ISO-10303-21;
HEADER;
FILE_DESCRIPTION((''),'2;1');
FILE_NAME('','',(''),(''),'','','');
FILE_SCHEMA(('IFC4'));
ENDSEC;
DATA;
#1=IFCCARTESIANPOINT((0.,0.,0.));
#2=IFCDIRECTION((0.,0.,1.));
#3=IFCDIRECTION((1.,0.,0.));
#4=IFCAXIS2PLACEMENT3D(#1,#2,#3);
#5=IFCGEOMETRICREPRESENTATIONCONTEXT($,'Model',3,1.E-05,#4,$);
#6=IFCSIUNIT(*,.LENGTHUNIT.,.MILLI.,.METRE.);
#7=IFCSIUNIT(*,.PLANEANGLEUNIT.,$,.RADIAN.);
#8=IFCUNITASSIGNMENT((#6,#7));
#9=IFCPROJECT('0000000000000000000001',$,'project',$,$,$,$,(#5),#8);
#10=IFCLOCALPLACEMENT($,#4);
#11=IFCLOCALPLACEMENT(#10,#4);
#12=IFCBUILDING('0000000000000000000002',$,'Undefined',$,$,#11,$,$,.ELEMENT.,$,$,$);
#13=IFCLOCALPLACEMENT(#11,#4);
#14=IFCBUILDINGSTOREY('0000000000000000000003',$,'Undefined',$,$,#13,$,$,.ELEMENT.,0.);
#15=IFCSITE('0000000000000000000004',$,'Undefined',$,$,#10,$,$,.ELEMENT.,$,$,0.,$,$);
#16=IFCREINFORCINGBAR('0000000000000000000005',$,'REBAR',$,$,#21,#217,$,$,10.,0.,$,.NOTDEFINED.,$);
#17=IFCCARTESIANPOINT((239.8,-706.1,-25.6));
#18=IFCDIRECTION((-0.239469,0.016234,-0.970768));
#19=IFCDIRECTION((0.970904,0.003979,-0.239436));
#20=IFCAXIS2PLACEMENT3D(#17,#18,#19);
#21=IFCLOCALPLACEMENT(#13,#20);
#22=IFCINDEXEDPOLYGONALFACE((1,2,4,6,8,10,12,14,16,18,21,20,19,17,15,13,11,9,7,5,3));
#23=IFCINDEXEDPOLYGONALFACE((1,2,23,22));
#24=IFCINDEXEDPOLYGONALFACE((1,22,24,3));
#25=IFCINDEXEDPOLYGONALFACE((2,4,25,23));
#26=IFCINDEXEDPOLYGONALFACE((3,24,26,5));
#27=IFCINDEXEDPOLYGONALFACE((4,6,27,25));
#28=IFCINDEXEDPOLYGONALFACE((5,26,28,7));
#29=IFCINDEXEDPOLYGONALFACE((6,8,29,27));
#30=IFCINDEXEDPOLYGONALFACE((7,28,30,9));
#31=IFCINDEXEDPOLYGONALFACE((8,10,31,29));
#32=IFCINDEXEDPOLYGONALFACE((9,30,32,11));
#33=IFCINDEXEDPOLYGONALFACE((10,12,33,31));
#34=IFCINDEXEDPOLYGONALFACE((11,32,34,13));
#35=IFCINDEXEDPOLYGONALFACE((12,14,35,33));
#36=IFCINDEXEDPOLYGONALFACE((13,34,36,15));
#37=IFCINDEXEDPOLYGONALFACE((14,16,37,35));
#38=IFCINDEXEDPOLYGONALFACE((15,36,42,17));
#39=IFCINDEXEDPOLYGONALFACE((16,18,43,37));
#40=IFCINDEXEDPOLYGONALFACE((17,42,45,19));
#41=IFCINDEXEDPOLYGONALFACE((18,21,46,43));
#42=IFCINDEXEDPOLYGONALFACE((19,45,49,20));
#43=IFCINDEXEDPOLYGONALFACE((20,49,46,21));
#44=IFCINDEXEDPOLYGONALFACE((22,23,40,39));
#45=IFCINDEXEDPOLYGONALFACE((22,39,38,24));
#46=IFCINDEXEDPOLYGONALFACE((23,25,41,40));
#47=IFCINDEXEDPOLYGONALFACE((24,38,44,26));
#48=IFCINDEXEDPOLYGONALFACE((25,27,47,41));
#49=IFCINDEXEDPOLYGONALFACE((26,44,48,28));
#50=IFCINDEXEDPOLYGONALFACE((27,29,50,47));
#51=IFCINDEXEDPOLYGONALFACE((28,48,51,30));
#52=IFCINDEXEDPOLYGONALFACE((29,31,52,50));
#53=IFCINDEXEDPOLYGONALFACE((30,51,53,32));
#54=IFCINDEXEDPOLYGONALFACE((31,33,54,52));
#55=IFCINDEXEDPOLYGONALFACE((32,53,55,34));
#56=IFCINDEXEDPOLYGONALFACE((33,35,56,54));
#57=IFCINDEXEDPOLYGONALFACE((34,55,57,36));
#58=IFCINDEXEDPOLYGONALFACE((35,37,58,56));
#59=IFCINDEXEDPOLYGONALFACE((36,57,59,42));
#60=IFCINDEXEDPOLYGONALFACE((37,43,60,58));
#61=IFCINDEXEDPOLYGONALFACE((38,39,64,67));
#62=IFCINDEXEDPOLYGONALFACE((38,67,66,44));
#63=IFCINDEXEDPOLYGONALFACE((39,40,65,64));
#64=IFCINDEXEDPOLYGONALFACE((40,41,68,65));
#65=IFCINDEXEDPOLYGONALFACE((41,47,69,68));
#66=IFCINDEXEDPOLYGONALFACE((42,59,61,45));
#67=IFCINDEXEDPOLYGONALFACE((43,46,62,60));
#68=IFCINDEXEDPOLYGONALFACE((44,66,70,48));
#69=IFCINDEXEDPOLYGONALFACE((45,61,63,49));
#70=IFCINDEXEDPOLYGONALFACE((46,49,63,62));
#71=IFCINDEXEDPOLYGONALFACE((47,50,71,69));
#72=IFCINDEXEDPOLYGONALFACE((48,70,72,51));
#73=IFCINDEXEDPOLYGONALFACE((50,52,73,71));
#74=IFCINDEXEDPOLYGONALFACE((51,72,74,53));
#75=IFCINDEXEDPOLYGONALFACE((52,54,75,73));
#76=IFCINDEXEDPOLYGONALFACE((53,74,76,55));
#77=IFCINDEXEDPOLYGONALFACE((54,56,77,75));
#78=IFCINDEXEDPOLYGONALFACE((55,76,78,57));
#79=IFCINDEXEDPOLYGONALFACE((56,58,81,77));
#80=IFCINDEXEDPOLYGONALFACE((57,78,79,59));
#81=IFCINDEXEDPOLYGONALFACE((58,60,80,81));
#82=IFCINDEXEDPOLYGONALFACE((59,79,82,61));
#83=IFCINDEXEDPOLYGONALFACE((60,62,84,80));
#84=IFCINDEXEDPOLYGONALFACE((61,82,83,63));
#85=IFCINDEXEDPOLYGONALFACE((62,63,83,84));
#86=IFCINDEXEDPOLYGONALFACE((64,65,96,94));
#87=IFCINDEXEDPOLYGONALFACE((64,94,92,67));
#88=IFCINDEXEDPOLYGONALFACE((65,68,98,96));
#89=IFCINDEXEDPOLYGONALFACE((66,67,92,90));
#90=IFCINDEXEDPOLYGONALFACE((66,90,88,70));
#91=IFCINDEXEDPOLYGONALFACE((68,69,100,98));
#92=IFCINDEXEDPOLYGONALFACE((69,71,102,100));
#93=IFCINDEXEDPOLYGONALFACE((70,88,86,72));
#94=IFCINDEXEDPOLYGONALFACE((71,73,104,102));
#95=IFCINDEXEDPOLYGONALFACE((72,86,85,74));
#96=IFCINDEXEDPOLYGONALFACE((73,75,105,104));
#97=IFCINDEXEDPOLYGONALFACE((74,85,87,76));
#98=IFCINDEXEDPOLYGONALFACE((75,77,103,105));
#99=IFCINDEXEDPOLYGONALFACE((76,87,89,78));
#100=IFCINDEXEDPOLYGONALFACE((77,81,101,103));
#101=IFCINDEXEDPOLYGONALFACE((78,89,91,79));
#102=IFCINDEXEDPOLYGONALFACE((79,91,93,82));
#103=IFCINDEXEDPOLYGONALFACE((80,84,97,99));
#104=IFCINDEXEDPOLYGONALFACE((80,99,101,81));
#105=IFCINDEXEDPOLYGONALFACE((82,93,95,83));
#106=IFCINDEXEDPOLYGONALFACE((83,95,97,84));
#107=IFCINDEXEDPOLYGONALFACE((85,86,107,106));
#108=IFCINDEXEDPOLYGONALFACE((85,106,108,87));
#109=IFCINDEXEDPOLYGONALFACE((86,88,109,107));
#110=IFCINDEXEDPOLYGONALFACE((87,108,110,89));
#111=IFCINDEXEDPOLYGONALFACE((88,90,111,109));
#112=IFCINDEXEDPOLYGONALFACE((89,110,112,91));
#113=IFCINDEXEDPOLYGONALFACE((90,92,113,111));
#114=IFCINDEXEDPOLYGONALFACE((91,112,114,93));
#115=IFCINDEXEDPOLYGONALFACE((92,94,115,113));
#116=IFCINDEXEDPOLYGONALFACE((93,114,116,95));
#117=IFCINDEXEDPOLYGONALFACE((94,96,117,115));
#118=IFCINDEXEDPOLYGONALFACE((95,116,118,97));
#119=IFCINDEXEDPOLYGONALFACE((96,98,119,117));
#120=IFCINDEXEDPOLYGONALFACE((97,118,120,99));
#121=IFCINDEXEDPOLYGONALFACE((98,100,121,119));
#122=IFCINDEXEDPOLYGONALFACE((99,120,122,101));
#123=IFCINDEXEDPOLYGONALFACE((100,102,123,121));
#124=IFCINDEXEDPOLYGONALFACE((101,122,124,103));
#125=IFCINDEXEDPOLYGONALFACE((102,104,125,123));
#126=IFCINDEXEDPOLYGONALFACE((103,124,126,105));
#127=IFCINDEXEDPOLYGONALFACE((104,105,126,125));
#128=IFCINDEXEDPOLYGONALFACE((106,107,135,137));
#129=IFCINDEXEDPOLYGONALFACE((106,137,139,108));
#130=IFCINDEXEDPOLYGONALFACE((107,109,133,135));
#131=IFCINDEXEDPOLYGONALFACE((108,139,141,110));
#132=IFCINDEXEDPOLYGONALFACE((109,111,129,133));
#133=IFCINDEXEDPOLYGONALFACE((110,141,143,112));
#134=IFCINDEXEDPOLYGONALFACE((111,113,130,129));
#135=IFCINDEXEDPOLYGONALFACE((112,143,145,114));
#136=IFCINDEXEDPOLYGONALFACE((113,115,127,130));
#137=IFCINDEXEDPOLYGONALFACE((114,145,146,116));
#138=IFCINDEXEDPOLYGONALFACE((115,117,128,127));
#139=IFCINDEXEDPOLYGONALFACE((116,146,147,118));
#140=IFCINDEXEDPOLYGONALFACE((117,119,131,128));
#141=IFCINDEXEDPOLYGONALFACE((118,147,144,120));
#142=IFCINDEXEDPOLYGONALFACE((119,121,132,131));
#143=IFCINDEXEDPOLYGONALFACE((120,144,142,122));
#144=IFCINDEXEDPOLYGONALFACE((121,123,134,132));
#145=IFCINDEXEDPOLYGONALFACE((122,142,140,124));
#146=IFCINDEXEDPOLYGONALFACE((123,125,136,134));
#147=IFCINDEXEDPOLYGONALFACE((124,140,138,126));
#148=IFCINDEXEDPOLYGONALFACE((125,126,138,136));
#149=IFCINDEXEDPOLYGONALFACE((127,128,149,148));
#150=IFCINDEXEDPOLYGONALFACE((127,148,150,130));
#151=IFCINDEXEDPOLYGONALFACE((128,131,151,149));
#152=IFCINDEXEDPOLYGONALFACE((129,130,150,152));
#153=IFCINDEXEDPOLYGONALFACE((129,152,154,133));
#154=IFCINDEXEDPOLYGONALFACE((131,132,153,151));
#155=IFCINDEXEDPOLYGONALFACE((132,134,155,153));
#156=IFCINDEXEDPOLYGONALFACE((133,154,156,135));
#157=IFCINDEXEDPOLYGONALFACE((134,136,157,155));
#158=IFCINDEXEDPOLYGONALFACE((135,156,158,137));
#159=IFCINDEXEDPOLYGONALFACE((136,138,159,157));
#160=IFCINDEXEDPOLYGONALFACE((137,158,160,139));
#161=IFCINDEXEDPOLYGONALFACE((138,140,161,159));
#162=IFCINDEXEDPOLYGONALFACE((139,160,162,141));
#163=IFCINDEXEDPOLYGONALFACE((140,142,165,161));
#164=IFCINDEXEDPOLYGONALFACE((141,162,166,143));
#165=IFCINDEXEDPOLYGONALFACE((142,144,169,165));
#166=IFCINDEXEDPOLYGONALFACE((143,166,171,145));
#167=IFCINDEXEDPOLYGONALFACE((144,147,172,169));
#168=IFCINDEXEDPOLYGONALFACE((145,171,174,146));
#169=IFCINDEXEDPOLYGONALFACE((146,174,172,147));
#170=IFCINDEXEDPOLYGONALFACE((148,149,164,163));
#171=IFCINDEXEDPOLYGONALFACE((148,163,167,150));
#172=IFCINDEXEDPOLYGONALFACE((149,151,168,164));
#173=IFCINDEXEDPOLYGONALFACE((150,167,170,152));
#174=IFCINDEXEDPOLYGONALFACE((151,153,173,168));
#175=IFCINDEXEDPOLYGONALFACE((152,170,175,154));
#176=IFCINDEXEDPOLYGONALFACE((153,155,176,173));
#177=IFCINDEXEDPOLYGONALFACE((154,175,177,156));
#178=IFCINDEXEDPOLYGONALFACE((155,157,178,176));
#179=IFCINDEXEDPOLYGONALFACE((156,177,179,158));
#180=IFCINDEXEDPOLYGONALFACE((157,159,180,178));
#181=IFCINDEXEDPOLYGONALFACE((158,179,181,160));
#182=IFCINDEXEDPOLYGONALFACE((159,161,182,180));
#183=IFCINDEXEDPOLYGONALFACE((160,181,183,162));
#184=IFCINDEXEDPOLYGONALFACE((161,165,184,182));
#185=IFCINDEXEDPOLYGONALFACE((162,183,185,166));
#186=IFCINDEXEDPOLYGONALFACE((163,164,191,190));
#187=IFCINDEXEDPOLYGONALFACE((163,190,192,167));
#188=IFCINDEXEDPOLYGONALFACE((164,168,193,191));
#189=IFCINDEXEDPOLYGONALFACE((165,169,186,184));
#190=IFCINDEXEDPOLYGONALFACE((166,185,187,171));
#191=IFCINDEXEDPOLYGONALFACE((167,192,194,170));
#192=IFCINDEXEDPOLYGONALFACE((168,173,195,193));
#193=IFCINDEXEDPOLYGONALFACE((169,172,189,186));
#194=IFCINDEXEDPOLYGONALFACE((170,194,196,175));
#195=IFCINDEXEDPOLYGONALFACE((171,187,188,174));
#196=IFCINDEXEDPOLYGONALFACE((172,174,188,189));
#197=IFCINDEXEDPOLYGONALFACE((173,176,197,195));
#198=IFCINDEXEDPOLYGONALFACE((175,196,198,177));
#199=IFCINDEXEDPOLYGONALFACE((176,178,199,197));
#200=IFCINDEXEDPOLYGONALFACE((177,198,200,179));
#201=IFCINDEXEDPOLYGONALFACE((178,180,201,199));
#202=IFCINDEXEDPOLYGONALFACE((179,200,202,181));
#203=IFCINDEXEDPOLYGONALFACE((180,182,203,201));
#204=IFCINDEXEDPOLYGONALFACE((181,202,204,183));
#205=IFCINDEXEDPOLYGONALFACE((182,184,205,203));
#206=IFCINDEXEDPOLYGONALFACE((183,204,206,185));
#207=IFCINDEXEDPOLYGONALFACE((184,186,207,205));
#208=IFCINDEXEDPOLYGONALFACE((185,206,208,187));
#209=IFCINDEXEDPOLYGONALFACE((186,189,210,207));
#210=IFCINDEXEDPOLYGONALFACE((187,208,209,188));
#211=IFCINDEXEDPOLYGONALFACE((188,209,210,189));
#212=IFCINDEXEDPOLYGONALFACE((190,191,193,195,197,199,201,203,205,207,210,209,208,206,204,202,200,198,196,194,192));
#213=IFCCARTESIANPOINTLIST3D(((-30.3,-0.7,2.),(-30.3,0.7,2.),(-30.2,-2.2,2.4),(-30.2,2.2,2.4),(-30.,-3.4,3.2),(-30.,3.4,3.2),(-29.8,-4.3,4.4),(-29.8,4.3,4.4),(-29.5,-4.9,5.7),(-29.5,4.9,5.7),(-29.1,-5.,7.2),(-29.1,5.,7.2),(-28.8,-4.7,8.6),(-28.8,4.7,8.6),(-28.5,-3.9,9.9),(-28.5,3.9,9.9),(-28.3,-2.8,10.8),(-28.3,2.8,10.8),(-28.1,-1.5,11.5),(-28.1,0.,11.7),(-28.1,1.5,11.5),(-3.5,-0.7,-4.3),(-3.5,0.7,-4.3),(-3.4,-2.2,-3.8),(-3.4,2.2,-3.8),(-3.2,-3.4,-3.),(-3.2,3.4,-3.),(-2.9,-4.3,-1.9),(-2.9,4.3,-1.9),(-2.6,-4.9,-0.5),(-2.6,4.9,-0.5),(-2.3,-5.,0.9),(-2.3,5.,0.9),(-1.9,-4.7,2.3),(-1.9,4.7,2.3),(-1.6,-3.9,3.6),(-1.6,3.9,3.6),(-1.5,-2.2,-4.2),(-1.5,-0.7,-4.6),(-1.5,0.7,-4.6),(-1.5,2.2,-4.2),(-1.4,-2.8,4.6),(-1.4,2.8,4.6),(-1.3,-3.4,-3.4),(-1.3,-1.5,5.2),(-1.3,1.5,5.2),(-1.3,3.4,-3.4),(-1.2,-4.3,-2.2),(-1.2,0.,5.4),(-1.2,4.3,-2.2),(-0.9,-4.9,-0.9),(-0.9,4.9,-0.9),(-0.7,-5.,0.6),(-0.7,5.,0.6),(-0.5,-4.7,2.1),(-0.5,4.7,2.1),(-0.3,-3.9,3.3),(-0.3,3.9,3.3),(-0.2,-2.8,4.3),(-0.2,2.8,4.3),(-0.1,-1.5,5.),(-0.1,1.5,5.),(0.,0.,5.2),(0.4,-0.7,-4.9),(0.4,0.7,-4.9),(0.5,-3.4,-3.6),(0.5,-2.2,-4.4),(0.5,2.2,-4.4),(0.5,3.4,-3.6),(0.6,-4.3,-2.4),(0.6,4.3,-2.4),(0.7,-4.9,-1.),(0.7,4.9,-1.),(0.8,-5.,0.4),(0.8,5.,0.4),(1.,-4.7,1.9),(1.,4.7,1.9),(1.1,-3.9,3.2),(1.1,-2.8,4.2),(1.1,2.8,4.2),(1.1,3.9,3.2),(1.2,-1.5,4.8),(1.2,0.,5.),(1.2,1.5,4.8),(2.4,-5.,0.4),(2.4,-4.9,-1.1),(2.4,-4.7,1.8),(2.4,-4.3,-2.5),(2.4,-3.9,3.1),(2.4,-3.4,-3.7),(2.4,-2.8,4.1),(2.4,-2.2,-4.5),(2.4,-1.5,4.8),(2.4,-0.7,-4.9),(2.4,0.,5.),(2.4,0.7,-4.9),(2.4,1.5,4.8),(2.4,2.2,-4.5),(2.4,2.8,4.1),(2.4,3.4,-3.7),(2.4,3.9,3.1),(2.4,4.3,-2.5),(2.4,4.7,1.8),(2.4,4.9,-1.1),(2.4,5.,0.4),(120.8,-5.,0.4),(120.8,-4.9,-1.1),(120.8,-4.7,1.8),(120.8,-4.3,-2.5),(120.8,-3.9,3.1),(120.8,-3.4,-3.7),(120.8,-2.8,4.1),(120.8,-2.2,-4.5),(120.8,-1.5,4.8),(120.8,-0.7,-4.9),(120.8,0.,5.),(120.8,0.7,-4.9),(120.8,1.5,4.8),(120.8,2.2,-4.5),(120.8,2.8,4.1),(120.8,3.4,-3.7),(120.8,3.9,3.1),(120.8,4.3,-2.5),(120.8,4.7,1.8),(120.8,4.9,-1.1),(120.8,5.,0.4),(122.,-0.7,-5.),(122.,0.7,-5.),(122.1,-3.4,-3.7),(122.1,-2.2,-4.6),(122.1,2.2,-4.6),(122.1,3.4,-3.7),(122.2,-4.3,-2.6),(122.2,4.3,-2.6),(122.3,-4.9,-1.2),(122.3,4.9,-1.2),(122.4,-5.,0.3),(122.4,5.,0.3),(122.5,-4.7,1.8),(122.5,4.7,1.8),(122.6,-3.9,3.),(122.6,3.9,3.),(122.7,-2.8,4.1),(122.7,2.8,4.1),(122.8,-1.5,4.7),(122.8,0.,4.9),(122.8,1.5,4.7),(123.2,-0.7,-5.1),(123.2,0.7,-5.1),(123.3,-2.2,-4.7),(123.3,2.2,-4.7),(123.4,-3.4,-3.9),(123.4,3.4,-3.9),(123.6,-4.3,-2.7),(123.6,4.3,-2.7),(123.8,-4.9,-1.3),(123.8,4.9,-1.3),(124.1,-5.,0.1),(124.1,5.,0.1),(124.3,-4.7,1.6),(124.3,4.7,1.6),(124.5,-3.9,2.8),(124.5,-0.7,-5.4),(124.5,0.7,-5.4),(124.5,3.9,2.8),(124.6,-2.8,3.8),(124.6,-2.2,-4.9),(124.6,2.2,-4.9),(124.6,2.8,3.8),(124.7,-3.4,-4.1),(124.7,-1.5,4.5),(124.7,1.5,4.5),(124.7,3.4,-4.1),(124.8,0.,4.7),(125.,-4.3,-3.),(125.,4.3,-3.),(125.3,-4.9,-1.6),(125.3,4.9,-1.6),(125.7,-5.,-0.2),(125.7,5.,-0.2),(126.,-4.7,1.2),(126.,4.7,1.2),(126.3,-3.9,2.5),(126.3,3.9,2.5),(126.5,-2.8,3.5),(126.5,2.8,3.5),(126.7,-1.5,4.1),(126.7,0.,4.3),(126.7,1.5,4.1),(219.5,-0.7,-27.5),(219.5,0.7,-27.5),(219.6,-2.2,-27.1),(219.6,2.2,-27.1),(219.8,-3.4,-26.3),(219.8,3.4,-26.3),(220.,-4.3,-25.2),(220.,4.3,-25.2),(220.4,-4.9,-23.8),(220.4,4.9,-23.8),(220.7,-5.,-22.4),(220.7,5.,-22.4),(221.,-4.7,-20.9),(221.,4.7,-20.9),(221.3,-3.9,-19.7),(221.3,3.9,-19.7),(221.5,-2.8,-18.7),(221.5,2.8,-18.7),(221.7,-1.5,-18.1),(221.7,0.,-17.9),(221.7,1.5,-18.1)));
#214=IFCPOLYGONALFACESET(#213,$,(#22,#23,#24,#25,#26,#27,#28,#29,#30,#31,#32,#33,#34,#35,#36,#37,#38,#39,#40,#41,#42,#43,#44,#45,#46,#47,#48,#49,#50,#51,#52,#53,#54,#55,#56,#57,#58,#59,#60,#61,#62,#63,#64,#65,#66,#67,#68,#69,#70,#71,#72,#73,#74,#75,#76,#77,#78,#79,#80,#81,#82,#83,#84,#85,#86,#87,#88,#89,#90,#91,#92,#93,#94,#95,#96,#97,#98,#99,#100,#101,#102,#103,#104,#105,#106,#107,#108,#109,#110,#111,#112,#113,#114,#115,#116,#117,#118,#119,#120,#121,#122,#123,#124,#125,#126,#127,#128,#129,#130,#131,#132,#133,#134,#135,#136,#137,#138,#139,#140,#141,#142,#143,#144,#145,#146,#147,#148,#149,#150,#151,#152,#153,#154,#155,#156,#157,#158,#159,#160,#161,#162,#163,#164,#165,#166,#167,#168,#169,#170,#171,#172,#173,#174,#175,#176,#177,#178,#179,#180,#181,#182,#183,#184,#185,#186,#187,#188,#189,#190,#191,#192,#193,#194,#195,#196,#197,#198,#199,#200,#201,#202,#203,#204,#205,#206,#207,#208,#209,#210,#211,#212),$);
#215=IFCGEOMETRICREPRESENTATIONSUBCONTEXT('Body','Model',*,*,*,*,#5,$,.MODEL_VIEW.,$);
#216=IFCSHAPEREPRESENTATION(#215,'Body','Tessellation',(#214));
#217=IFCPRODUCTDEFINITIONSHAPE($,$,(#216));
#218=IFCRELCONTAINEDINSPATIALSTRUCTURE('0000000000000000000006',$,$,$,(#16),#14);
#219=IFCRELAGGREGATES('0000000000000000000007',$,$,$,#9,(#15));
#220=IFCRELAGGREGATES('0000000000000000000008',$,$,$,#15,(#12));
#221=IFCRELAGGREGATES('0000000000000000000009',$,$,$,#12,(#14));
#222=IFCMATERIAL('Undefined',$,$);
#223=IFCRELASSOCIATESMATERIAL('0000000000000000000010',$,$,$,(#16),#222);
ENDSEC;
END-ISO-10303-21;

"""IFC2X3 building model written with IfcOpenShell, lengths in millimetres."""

from ifc_helpers import new_model, entity, si_unit, frame, origin_with_axes, place, context, subcontext, project, spatial, source, transform, mapped, material, element, save


model = new_model("IFC2X3")

# Units and contexts
model_context = context("Model", 3, precision=1e-05, world=origin_with_axes())
body_context = subcontext(model_context, "Body", "Model", "MODEL_VIEW")
ifc_project = project(units=[si_unit("LENGTHUNIT", "METRE", prefix="MILLI"), si_unit("PLANEANGLEUNIT", "RADIAN")], contexts=[model_context])

# Site, building, storey
site_placement = place(None, origin_with_axes())
site = spatial("IfcSite", under=ifc_project, at=site_placement, Name="Undefined", CompositionType="ELEMENT", RefElevation=0.0)
building_placement = place(site_placement, origin_with_axes())
building = spatial("IfcBuilding", under=site, at=building_placement, Name="Undefined", CompositionType="ELEMENT")
storey_placement = place(building_placement, origin_with_axes())
storey = spatial("IfcBuildingStorey", under=building, at=storey_placement, Name="Undefined", CompositionType="ELEMENT", Elevation=0.0)

# Reinforcing bar
ifc_material_1 = material(Name="Undefined")
ifc_direction_1 = entity("IfcDirection", [0.973841, 0.0, -0.22723])
shared_shape_1 = source(origin_with_axes(), body_context, "Body", "AdvancedSweptSolid", [
    entity("IfcSweptDiskSolid", entity("IfcCompositeCurve", [entity("IfcCompositeCurveSegment", "CONTINUOUS", True, entity("IfcTrimmedCurve", entity("IfcLine", entity("IfcCartesianPoint", [0.0, 0.0, 0.0]), entity("IfcVector", ifc_direction_1, 1.0)), [entity("IfcParameterValue", 0.0)], [entity("IfcParameterValue", 27.582469)], True, "PARAMETER")), entity("IfcCompositeCurveSegment", "CONTINUOUS", True, entity("IfcTrimmedCurve", entity("IfcCircle", entity("IfcAxis2Placement3D", entity("IfcCartesianPoint", [31.6, 0.0, 14.2]), entity("IfcDirection", [0.0, -1.0, 0.0]), entity("IfcDirection", [-0.22723, 0.0, -0.973841])), 21.0), [entity("IfcParameterValue", 0.0)], [entity("IfcParameterValue", 0.229232)], True, "PARAMETER")), entity("IfcCompositeCurveSegment", "CONTINUOUS", True, entity("IfcTrimmedCurve", entity("IfcLine", entity("IfcCartesianPoint", [31.6, 0.0, -6.8]), entity("IfcVector", entity("IfcDirection", [1.0, 0.0, 0.0]), 1.0)), [entity("IfcParameterValue", 0.0)], [entity("IfcParameterValue", 118.388313)], True, "PARAMETER")), entity("IfcCompositeCurveSegment", "CONTINUOUS", True, entity("IfcTrimmedCurve", entity("IfcCircle", entity("IfcAxis2Placement3D", entity("IfcCartesianPoint", [150.0, 0.0, -27.8]), entity("IfcDirection", [0.0, 1.0, 0.0]), entity("IfcDirection", [0.0, 0.0, 1.0])), 21.0), [entity("IfcParameterValue", 0.0)], [entity("IfcParameterValue", 0.229232)], True, "PARAMETER")), entity("IfcCompositeCurveSegment", "DISCONTINUOUS", True, entity("IfcTrimmedCurve", entity("IfcLine", entity("IfcCartesianPoint", [154.8, 0.0, -7.4]), entity("IfcVector", ifc_direction_1, 1.0)), [entity("IfcParameterValue", 0.0)], [entity("IfcParameterValue", 97.582469)], True, "PARAMETER"))], False), 5.0, None, 0.0, 244.0),
])
reinforcing_bar_1_placement = place(storey_placement, frame((239.8, -706.1, -25.6), z_axis=(-0.239469, 0.016234, -0.970768), x_axis=(0.970904, 0.003979, -0.239436)))
element("IfcReinforcingBar", 1, at=reinforcing_bar_1_placement, inside=storey, material=ifc_material_1, Name="REBAR", BarRole="NOTDEFINED", CrossSectionArea=0.0, NominalDiameter=10.0, context=body_context, shape_type="MappedRepresentation", body=[
    mapped(shared_shape_1, transform((-29.2, 0.0, 6.8))),
])

save(model, "model.ifc")
